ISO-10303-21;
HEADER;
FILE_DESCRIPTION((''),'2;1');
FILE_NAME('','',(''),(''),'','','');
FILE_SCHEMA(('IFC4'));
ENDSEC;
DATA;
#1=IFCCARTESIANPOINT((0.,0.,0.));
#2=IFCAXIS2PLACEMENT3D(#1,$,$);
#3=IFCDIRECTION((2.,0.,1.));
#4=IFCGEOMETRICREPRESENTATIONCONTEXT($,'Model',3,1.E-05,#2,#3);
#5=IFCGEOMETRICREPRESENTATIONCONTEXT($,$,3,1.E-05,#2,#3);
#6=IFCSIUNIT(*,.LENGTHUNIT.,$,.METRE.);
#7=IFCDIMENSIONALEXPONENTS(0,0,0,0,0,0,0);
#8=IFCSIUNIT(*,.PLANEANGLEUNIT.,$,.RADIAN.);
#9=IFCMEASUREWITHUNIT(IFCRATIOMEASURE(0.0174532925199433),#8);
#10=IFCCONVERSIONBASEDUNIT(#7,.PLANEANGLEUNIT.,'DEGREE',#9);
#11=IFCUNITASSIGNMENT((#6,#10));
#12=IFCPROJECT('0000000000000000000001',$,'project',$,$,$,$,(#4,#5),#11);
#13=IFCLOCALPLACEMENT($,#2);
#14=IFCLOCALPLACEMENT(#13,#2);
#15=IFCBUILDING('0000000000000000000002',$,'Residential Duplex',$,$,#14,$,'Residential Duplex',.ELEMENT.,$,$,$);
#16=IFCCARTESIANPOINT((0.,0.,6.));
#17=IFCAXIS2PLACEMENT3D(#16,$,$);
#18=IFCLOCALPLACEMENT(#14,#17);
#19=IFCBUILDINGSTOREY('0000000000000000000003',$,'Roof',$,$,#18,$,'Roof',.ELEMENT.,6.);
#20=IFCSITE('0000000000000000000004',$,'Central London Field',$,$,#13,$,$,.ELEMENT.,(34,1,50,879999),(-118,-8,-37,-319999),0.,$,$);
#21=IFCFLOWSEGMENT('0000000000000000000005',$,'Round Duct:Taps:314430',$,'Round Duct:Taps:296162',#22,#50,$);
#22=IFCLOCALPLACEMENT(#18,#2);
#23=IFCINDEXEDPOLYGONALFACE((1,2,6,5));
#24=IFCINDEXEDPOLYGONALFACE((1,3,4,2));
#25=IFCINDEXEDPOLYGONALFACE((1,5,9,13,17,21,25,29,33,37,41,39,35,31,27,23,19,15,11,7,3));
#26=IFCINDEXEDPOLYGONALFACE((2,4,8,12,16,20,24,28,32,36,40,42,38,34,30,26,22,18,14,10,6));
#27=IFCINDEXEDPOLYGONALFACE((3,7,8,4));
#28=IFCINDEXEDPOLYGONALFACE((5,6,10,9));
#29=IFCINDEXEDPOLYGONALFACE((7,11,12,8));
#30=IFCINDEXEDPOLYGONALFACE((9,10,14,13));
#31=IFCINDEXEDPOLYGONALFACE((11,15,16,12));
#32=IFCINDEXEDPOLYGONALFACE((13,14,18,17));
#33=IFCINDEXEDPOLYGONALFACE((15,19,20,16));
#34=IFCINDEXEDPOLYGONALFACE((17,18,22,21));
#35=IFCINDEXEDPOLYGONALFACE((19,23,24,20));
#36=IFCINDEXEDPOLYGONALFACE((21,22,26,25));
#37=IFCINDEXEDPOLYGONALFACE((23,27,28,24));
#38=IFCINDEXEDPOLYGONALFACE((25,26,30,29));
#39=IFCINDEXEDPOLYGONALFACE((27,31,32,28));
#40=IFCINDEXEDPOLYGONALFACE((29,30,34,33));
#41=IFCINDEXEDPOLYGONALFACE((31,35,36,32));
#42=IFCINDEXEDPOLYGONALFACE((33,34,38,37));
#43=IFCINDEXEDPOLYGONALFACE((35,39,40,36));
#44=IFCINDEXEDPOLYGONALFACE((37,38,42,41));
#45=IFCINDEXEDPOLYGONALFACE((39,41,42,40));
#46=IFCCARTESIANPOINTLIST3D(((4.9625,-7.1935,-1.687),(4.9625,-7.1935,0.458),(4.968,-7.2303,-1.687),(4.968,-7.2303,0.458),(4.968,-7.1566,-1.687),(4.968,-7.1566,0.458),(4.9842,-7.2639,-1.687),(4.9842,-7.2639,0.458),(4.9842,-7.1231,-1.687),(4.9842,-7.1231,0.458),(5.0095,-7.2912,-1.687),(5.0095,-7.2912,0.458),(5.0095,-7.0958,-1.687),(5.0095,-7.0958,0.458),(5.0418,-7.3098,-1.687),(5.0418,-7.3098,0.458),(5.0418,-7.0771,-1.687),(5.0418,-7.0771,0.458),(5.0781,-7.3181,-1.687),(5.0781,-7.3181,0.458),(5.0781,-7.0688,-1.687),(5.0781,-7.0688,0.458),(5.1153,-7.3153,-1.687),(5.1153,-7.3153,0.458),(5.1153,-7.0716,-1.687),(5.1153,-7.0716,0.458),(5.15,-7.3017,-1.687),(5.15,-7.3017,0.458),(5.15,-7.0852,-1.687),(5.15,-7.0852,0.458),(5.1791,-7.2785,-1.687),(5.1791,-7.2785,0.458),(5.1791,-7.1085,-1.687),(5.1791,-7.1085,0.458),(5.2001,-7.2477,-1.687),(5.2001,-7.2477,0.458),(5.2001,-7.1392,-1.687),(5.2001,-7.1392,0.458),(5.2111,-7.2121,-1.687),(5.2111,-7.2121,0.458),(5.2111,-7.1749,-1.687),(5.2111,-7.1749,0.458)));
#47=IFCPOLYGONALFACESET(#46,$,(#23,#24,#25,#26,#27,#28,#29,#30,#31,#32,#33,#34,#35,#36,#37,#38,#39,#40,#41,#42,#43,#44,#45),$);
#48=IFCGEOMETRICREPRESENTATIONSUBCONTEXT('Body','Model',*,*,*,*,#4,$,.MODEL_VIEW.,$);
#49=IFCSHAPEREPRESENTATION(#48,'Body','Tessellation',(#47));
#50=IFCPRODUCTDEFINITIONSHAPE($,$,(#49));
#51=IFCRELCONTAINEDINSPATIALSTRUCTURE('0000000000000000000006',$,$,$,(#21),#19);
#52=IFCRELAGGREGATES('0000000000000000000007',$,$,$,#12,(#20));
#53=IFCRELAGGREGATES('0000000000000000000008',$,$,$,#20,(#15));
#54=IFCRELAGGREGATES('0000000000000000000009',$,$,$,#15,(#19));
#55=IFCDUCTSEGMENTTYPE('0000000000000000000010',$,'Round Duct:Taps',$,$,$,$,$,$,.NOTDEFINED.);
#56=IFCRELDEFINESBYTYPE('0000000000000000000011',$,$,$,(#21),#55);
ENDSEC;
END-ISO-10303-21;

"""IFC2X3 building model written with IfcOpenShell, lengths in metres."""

from ifc_helpers import new_model, entity, si_unit, converted_unit, direction, frame, frame_2d, origin, place, context, subcontext, project, spatial, circle, extrude, type_object, element, save


model = new_model("IFC2X3")

# Units and contexts
model_context = context("Model", 3, precision=1e-05, world=origin(), true_north=direction((2.0, 0.0, 1.0)))
context_of_model = context(None, 3, precision=1e-05, world=origin(), true_north=direction((2.0, 0.0, 1.0)))
body_context = subcontext(model_context, "Body", "Model", "MODEL_VIEW")
ifc_project = project(units=[si_unit("LENGTHUNIT", "METRE"), converted_unit("PLANEANGLEUNIT", "DEGREE", entity("IfcRatioMeasure", 0.0174532925199433), si_unit("PLANEANGLEUNIT", "RADIAN"), dimensions=[0, 0, 0, 0, 0, 0, 0])], contexts=[model_context, context_of_model])

# Site, building, storey
site_placement = place(None, origin())
site = spatial("IfcSite", under=ifc_project, at=site_placement, Name="Central London Field", CompositionType="ELEMENT", RefLatitude=(34, 1, 50, 879999), RefLongitude=(-118, -8, -37, -319999), RefElevation=0.0)
building_placement = place(site_placement, origin())
building = spatial("IfcBuilding", under=site, at=building_placement, Name="Residential Duplex", LongName="Residential Duplex", CompositionType="ELEMENT")
storey_placement = place(building_placement, frame((0.0, 0.0, 6.0)))
storey = spatial("IfcBuildingStorey", under=building, at=storey_placement, Name="Roof", LongName="Roof", CompositionType="ELEMENT", Elevation=6.0)

# Flow segment
duct_segment_type = type_object("IfcDuctSegmentType", Name="Round Duct:Taps", PredefinedType="NOTDEFINED")
flow_segment_placement = place(storey_placement, origin())
element("IfcFlowSegment", 1, at=flow_segment_placement, inside=storey, type_object=duct_segment_type, Name="Round Duct:Taps:314430", ObjectType="Round Duct:Taps:296162", context=body_context, shape_type="SweptSolid", body=[
    extrude(circle(Radius=0.125, at=frame_2d((0.0, 0.0), x_axis=(1.0, 0.0))), frame((5.0875, -7.1935, -1.687), z_axis=(0.0, 0.0, 1.0), x_axis=(-1.0, 0.0, 0.0)), (0.0, 0.0, 1.0), 2.145),
])

save(model, "model.ifc")
